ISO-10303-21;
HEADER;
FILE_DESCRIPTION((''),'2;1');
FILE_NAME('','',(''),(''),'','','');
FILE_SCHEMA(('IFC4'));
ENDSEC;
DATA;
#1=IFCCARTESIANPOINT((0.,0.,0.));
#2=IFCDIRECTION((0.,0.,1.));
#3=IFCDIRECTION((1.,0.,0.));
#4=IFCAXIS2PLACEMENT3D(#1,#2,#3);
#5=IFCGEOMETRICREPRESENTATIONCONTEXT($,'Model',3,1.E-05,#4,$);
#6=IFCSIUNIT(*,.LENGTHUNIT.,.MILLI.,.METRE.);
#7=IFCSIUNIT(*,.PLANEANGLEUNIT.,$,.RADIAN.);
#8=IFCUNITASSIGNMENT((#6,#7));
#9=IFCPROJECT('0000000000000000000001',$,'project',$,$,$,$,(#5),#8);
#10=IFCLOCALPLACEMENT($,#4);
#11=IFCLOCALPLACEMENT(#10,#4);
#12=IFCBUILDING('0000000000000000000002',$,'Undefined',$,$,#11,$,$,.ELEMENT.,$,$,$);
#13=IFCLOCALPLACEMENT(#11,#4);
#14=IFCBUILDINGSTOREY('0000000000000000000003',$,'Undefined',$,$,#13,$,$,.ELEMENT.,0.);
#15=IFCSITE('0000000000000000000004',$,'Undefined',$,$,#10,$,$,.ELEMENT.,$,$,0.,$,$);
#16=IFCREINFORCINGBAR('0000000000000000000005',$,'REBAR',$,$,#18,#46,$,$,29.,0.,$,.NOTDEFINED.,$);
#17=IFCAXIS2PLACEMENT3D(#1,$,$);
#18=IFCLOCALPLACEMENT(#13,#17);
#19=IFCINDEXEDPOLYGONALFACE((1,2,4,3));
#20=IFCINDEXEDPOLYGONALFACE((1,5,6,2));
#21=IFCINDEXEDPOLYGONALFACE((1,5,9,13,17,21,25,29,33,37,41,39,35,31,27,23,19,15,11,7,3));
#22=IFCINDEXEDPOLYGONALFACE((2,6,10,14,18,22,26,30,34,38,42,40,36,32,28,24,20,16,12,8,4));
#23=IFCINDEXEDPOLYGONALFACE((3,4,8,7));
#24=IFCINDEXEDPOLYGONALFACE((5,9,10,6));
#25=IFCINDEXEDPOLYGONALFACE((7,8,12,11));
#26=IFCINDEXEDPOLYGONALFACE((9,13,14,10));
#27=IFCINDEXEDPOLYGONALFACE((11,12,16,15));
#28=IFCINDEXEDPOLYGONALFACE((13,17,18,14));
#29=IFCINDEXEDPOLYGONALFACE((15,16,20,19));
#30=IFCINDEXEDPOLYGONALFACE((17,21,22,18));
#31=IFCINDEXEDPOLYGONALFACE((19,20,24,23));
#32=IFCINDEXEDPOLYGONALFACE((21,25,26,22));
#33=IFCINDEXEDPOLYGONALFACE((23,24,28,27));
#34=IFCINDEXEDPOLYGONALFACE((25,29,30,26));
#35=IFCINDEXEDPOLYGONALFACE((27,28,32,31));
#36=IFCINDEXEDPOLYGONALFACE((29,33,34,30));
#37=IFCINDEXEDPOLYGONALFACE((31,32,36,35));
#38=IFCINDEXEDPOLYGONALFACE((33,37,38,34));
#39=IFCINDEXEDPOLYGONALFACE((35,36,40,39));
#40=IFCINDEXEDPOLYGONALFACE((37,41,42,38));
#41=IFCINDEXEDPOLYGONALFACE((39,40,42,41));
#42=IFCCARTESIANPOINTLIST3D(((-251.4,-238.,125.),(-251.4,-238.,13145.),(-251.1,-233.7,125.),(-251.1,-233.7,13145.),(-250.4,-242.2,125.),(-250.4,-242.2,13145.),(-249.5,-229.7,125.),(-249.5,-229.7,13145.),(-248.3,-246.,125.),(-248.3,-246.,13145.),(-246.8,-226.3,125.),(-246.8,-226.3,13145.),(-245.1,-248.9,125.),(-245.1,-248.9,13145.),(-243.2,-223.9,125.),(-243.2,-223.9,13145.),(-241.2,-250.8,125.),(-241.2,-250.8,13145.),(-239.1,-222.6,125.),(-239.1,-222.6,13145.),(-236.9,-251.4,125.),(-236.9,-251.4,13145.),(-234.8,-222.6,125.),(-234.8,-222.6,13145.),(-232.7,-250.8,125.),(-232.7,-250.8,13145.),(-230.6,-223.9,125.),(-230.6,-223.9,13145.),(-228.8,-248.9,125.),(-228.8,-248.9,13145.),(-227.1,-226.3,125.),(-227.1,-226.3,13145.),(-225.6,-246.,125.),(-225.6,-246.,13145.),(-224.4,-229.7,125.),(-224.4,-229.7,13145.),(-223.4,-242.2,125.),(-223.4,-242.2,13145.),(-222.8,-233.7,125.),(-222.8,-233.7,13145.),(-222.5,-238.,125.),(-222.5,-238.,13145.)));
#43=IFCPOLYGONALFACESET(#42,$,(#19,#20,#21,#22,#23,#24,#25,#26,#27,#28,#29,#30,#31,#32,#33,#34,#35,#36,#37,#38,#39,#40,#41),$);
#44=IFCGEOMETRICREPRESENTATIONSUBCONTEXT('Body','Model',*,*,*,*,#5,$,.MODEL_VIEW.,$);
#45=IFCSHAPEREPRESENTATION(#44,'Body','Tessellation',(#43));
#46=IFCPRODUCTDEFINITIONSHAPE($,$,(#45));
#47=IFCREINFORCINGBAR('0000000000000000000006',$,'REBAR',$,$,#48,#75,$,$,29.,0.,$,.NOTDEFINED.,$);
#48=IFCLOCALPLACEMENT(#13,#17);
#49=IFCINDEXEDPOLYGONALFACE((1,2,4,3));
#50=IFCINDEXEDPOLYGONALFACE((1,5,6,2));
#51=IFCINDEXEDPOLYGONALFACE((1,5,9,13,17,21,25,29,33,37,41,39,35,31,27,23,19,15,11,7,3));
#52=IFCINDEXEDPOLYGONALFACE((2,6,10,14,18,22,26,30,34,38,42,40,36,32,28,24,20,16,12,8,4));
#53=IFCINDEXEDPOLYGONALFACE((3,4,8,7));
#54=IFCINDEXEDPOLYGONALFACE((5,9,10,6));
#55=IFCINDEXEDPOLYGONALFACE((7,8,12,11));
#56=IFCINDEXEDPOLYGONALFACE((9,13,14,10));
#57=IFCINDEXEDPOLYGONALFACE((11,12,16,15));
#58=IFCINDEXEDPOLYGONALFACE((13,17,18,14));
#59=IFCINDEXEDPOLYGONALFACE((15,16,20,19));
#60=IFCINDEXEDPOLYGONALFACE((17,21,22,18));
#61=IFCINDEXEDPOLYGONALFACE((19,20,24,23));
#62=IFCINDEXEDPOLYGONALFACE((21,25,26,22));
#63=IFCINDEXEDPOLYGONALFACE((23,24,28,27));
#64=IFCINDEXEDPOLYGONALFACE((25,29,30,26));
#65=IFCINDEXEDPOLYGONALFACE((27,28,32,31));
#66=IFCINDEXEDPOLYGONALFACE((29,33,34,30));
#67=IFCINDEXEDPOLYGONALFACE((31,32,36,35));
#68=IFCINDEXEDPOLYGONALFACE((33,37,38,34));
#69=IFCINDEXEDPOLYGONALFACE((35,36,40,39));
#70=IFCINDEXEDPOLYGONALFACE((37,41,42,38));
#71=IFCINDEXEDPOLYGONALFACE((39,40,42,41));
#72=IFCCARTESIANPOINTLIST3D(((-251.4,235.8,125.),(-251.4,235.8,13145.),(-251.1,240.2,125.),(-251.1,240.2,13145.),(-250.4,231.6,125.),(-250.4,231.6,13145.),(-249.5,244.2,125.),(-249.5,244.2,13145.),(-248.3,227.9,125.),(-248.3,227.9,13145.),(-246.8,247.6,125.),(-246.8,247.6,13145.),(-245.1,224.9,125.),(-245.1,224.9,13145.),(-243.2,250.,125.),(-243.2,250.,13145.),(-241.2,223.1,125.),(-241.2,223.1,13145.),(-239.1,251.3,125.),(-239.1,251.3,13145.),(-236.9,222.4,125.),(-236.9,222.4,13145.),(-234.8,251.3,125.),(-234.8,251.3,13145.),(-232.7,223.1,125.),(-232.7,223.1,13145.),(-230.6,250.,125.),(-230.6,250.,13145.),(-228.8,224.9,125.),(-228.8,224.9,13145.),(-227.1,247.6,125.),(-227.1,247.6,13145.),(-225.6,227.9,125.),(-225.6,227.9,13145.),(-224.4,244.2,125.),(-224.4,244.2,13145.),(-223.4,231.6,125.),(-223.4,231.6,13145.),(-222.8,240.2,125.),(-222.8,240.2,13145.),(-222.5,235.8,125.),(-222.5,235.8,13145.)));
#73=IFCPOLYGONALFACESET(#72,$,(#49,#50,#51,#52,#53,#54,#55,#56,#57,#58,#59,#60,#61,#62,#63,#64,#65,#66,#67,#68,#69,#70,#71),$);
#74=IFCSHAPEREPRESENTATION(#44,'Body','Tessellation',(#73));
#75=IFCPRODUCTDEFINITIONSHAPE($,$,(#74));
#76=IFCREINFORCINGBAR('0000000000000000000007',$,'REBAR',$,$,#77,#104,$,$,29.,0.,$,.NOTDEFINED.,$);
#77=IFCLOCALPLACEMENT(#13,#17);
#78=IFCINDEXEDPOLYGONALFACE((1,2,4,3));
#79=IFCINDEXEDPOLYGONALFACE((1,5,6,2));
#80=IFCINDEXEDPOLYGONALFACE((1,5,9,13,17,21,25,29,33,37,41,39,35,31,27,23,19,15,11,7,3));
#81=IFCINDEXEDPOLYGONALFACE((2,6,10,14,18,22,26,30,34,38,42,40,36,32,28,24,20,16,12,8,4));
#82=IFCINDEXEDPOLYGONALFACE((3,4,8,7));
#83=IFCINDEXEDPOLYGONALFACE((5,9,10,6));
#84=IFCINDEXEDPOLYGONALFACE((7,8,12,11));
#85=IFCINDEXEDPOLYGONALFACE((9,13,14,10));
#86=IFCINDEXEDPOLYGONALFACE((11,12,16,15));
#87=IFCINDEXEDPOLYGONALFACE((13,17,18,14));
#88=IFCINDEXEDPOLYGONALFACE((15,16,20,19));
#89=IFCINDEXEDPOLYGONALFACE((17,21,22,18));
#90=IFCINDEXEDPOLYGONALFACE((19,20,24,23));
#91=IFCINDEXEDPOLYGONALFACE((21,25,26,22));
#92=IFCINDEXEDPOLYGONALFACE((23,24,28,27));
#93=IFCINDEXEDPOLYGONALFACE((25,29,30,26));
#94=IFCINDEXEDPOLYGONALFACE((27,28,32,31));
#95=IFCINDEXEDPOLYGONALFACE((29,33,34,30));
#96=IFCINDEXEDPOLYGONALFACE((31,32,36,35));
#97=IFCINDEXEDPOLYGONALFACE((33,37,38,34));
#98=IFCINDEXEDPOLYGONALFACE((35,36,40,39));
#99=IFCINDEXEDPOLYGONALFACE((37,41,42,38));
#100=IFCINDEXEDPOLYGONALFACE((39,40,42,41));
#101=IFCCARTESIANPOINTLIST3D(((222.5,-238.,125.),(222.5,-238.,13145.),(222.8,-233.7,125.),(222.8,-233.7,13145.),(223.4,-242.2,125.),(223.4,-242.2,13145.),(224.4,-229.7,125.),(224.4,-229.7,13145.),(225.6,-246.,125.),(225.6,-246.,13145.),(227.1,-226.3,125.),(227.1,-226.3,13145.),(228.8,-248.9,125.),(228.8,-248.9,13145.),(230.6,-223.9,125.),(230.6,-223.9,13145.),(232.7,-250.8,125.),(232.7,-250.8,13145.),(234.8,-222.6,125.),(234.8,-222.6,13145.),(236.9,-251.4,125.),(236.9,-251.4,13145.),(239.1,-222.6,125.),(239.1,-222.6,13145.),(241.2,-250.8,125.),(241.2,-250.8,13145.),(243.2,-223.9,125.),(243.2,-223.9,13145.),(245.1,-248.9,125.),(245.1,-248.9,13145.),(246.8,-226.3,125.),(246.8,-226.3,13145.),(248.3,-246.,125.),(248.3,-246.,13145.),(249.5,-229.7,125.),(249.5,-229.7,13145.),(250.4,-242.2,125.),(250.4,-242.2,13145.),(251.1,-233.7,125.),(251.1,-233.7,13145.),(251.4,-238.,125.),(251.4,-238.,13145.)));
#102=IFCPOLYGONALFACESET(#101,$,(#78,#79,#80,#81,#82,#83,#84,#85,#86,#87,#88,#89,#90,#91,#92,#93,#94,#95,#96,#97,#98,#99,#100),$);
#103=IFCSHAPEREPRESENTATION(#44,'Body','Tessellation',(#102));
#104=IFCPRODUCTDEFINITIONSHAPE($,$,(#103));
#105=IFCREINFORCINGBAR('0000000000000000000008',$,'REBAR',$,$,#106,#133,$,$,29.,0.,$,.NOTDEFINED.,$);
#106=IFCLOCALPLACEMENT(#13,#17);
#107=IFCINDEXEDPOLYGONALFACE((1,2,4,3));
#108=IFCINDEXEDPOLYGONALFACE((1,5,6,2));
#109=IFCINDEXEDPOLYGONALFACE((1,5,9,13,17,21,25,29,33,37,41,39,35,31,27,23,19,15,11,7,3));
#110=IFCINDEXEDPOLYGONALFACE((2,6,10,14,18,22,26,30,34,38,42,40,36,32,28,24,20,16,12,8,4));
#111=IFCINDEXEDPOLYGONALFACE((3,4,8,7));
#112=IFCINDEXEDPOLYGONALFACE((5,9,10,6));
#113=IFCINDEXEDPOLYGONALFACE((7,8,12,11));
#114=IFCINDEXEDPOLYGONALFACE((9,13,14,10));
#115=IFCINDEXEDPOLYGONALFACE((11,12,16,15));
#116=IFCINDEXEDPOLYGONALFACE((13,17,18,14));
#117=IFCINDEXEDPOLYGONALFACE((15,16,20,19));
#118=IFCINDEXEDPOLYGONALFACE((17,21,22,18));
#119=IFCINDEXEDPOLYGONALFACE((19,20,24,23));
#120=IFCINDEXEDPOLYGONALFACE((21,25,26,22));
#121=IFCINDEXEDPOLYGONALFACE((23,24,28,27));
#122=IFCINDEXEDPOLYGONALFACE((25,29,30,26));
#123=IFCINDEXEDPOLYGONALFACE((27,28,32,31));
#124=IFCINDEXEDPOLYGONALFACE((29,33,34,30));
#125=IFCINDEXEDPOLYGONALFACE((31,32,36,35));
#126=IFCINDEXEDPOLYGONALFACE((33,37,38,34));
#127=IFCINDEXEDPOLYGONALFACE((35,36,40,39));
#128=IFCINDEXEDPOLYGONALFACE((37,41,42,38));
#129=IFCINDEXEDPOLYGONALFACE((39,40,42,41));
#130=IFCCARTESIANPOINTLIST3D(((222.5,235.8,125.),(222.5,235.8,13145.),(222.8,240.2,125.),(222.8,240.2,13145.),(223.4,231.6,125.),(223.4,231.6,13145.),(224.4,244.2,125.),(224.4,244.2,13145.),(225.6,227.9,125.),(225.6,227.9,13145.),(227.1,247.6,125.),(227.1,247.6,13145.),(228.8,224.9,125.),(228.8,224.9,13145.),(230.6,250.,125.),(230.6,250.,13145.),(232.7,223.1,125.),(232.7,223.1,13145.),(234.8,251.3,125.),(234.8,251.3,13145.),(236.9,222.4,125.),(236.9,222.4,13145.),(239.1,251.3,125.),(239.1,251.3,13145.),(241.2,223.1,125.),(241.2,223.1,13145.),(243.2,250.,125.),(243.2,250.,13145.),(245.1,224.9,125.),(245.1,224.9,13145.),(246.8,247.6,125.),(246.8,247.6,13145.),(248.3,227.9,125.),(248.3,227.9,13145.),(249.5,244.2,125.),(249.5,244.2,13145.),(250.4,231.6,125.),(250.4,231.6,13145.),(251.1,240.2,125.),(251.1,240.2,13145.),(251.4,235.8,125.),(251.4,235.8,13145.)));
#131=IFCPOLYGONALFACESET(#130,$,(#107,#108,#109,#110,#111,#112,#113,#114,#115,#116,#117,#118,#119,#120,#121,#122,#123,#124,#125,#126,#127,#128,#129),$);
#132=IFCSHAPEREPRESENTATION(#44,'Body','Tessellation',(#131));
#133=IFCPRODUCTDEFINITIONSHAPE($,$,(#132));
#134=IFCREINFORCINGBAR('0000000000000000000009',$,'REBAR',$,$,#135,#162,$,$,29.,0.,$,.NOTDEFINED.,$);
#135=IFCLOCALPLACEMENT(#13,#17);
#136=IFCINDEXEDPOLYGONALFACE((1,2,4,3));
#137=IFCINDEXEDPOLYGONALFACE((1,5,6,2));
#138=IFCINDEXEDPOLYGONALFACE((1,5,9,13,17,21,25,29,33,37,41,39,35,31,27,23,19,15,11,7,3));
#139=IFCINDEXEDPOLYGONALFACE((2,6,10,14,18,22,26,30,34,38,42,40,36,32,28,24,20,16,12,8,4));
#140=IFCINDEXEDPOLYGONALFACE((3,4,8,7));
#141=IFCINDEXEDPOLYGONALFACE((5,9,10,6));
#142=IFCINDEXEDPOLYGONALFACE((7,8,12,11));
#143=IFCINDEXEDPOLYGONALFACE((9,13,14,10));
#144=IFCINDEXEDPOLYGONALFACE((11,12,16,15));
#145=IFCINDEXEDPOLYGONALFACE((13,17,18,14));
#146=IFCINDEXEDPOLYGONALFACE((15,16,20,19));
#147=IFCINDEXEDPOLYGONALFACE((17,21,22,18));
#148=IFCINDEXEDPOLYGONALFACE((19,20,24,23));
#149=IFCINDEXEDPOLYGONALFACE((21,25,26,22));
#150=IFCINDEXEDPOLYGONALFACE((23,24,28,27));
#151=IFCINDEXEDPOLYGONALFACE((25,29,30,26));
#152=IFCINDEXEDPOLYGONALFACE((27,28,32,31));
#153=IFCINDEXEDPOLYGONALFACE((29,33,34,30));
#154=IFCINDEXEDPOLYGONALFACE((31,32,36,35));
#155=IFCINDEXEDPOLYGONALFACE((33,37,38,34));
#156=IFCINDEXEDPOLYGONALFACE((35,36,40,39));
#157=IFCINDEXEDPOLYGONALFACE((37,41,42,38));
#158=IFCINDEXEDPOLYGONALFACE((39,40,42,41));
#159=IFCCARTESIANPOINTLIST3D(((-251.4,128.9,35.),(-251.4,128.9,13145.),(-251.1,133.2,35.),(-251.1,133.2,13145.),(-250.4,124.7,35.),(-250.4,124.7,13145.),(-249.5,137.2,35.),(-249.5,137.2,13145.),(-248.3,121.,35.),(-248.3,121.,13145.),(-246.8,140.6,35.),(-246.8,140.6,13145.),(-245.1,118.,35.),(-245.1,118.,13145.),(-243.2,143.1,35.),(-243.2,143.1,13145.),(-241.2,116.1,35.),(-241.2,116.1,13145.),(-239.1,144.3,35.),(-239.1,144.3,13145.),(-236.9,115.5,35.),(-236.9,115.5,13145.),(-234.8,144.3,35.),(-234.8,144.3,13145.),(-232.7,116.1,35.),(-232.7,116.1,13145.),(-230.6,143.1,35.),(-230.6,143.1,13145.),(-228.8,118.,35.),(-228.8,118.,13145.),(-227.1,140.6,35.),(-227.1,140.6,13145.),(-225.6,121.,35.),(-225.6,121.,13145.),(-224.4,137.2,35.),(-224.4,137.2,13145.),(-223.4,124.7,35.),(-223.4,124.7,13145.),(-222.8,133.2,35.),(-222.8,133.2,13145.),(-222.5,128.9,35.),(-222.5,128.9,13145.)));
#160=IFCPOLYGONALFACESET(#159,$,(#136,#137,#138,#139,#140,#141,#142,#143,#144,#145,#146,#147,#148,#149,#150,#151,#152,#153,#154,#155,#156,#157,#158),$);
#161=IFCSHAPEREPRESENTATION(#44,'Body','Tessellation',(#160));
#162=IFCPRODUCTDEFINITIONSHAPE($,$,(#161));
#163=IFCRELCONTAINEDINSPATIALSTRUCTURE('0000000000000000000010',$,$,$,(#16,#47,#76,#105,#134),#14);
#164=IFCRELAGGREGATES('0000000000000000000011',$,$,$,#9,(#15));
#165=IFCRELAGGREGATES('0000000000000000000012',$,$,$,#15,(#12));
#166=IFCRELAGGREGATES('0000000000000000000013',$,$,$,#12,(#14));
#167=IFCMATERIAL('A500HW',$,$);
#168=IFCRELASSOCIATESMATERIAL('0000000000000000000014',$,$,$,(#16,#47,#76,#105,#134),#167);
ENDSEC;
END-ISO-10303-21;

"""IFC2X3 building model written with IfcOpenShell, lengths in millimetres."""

from ifc_helpers import new_model, entity, si_unit, frame, origin_with_axes, place, context, subcontext, project, spatial, source, transform, mapped, material, element, save


model = new_model("IFC2X3")

# Units and contexts
model_context = context("Model", 3, precision=1e-05, world=origin_with_axes())
body_context = subcontext(model_context, "Body", "Model", "MODEL_VIEW")
ifc_project = project(units=[si_unit("LENGTHUNIT", "METRE", prefix="MILLI"), si_unit("PLANEANGLEUNIT", "RADIAN")], contexts=[model_context])

# Site, building, storey
site_placement = place(None, origin_with_axes())
site = spatial("IfcSite", under=ifc_project, at=site_placement, Name="Undefined", CompositionType="ELEMENT", RefElevation=0.0)
building_placement = place(site_placement, origin_with_axes())
building = spatial("IfcBuilding", under=site, at=building_placement, Name="Undefined", CompositionType="ELEMENT")
storey_placement = place(building_placement, origin_with_axes())
storey = spatial("IfcBuildingStorey", under=building, at=storey_placement, Name="Undefined", CompositionType="ELEMENT", Elevation=0.0)

# Reinforcing bars
ifc_material_1 = material(Name="A500HW")
shared_shape_1 = source(origin_with_axes(), body_context, "Body", "AdvancedSweptSolid", [
    entity("IfcSweptDiskSolid", entity("IfcTrimmedCurve", entity("IfcLine", entity("IfcCartesianPoint", [0.0, 0.0, 0.0]), entity("IfcVector", entity("IfcDirection", [1.0, 0.0, 0.0]), 1.0)), [entity("IfcParameterValue", 0.0)], [entity("IfcParameterValue", 13020.03)], True, "PARAMETER"), 14.5, None, 0.0, 13020.0),
])
reinforcing_bar_1_placement = place(storey_placement, frame((-236.9, -236.9, 125.0), z_axis=(0.0, -1.0, 0.0), x_axis=(0.0, 0.0, 1.0)))
element("IfcReinforcingBar", 1, at=reinforcing_bar_1_placement, inside=storey, material=ifc_material_1, Name="REBAR", BarRole="NOTDEFINED", CrossSectionArea=0.0, NominalDiameter=29.0, context=body_context, shape_type="MappedRepresentation", body=[
    mapped(shared_shape_1, transform((0.0, 0.0, 0.0))),
])
shared_shape_2 = source(origin_with_axes(), body_context, "Body", "AdvancedSweptSolid", [
    entity("IfcSweptDiskSolid", entity("IfcTrimmedCurve", entity("IfcLine", entity("IfcCartesianPoint", [0.0, 0.0, 0.0]), entity("IfcVector", entity("IfcDirection", [1.0, 0.0, 0.0]), 1.0)), [entity("IfcParameterValue", 0.0)], [entity("IfcParameterValue", 13020.03)], True, "PARAMETER"), 14.5, None, 0.0, 13020.0),
])
reinforcing_bar_2_placement = place(storey_placement, frame((-236.9, 236.9, 125.0), z_axis=(0.0, -1.0, 0.0), x_axis=(0.0, 0.0, 1.0)))
element("IfcReinforcingBar", 2, at=reinforcing_bar_2_placement, inside=storey, material=ifc_material_1, Name="REBAR", BarRole="NOTDEFINED", CrossSectionArea=0.0, NominalDiameter=29.0, context=body_context, shape_type="MappedRepresentation", body=[
    mapped(shared_shape_2, transform((0.0, 0.0, 0.0))),
])
shared_shape_3 = source(origin_with_axes(), body_context, "Body", "AdvancedSweptSolid", [
    entity("IfcSweptDiskSolid", entity("IfcTrimmedCurve", entity("IfcLine", entity("IfcCartesianPoint", [0.0, 0.0, 0.0]), entity("IfcVector", entity("IfcDirection", [1.0, 0.0, 0.0]), 1.0)), [entity("IfcParameterValue", 0.0)], [entity("IfcParameterValue", 13020.03)], True, "PARAMETER"), 14.5, None, 0.0, 13020.0),
])
reinforcing_bar_3_placement = place(storey_placement, frame((236.9, -236.9, 125.0), z_axis=(0.0, -1.0, 0.0), x_axis=(0.0, 0.0, 1.0)))
element("IfcReinforcingBar", 3, at=reinforcing_bar_3_placement, inside=storey, material=ifc_material_1, Name="REBAR", BarRole="NOTDEFINED", CrossSectionArea=0.0, NominalDiameter=29.0, context=body_context, shape_type="MappedRepresentation", body=[
    mapped(shared_shape_3, transform((0.0, 0.0, 0.0))),
])
shared_shape_4 = source(origin_with_axes(), body_context, "Body", "AdvancedSweptSolid", [
    entity("IfcSweptDiskSolid", entity("IfcTrimmedCurve", entity("IfcLine", entity("IfcCartesianPoint", [0.0, 0.0, 0.0]), entity("IfcVector", entity("IfcDirection", [1.0, 0.0, 0.0]), 1.0)), [entity("IfcParameterValue", 0.0)], [entity("IfcParameterValue", 13020.03)], True, "PARAMETER"), 14.5, None, 0.0, 13020.0),
])
reinforcing_bar_4_placement = place(storey_placement, frame((236.9, 236.9, 125.0), z_axis=(0.0, -1.0, 0.0), x_axis=(0.0, 0.0, 1.0)))
element("IfcReinforcingBar", 4, at=reinforcing_bar_4_placement, inside=storey, material=ifc_material_1, Name="REBAR", BarRole="NOTDEFINED", CrossSectionArea=0.0, NominalDiameter=29.0, context=body_context, shape_type="MappedRepresentation", body=[
    mapped(shared_shape_4, transform((0.0, 0.0, 0.0))),
])
shared_shape_5 = source(origin_with_axes(), body_context, "Body", "AdvancedSweptSolid", [
    entity("IfcSweptDiskSolid", entity("IfcTrimmedCurve", entity("IfcLine", entity("IfcCartesianPoint", [0.0, 0.0, 0.0]), entity("IfcVector", entity("IfcDirection", [1.0, 0.0, 0.0]), 1.0)), [entity("IfcParameterValue", 0.0)], [entity("IfcParameterValue", 13110.03)], True, "PARAMETER"), 14.5, None, 0.0, 13110.0),
])
reinforcing_bar_5_placement = place(storey_placement, frame((-236.9, 130.0, 125.0), z_axis=(0.0, -1.0, 0.0), x_axis=(0.0, 0.0, 1.0)))
element("IfcReinforcingBar", 5, at=reinforcing_bar_5_placement, inside=storey, material=ifc_material_1, Name="REBAR", BarRole="NOTDEFINED", CrossSectionArea=0.0, NominalDiameter=29.0, context=body_context, shape_type="MappedRepresentation", body=[
    mapped(shared_shape_5, transform((-90.0, 0.0, 0.0))),
])

save(model, "model.ifc")
